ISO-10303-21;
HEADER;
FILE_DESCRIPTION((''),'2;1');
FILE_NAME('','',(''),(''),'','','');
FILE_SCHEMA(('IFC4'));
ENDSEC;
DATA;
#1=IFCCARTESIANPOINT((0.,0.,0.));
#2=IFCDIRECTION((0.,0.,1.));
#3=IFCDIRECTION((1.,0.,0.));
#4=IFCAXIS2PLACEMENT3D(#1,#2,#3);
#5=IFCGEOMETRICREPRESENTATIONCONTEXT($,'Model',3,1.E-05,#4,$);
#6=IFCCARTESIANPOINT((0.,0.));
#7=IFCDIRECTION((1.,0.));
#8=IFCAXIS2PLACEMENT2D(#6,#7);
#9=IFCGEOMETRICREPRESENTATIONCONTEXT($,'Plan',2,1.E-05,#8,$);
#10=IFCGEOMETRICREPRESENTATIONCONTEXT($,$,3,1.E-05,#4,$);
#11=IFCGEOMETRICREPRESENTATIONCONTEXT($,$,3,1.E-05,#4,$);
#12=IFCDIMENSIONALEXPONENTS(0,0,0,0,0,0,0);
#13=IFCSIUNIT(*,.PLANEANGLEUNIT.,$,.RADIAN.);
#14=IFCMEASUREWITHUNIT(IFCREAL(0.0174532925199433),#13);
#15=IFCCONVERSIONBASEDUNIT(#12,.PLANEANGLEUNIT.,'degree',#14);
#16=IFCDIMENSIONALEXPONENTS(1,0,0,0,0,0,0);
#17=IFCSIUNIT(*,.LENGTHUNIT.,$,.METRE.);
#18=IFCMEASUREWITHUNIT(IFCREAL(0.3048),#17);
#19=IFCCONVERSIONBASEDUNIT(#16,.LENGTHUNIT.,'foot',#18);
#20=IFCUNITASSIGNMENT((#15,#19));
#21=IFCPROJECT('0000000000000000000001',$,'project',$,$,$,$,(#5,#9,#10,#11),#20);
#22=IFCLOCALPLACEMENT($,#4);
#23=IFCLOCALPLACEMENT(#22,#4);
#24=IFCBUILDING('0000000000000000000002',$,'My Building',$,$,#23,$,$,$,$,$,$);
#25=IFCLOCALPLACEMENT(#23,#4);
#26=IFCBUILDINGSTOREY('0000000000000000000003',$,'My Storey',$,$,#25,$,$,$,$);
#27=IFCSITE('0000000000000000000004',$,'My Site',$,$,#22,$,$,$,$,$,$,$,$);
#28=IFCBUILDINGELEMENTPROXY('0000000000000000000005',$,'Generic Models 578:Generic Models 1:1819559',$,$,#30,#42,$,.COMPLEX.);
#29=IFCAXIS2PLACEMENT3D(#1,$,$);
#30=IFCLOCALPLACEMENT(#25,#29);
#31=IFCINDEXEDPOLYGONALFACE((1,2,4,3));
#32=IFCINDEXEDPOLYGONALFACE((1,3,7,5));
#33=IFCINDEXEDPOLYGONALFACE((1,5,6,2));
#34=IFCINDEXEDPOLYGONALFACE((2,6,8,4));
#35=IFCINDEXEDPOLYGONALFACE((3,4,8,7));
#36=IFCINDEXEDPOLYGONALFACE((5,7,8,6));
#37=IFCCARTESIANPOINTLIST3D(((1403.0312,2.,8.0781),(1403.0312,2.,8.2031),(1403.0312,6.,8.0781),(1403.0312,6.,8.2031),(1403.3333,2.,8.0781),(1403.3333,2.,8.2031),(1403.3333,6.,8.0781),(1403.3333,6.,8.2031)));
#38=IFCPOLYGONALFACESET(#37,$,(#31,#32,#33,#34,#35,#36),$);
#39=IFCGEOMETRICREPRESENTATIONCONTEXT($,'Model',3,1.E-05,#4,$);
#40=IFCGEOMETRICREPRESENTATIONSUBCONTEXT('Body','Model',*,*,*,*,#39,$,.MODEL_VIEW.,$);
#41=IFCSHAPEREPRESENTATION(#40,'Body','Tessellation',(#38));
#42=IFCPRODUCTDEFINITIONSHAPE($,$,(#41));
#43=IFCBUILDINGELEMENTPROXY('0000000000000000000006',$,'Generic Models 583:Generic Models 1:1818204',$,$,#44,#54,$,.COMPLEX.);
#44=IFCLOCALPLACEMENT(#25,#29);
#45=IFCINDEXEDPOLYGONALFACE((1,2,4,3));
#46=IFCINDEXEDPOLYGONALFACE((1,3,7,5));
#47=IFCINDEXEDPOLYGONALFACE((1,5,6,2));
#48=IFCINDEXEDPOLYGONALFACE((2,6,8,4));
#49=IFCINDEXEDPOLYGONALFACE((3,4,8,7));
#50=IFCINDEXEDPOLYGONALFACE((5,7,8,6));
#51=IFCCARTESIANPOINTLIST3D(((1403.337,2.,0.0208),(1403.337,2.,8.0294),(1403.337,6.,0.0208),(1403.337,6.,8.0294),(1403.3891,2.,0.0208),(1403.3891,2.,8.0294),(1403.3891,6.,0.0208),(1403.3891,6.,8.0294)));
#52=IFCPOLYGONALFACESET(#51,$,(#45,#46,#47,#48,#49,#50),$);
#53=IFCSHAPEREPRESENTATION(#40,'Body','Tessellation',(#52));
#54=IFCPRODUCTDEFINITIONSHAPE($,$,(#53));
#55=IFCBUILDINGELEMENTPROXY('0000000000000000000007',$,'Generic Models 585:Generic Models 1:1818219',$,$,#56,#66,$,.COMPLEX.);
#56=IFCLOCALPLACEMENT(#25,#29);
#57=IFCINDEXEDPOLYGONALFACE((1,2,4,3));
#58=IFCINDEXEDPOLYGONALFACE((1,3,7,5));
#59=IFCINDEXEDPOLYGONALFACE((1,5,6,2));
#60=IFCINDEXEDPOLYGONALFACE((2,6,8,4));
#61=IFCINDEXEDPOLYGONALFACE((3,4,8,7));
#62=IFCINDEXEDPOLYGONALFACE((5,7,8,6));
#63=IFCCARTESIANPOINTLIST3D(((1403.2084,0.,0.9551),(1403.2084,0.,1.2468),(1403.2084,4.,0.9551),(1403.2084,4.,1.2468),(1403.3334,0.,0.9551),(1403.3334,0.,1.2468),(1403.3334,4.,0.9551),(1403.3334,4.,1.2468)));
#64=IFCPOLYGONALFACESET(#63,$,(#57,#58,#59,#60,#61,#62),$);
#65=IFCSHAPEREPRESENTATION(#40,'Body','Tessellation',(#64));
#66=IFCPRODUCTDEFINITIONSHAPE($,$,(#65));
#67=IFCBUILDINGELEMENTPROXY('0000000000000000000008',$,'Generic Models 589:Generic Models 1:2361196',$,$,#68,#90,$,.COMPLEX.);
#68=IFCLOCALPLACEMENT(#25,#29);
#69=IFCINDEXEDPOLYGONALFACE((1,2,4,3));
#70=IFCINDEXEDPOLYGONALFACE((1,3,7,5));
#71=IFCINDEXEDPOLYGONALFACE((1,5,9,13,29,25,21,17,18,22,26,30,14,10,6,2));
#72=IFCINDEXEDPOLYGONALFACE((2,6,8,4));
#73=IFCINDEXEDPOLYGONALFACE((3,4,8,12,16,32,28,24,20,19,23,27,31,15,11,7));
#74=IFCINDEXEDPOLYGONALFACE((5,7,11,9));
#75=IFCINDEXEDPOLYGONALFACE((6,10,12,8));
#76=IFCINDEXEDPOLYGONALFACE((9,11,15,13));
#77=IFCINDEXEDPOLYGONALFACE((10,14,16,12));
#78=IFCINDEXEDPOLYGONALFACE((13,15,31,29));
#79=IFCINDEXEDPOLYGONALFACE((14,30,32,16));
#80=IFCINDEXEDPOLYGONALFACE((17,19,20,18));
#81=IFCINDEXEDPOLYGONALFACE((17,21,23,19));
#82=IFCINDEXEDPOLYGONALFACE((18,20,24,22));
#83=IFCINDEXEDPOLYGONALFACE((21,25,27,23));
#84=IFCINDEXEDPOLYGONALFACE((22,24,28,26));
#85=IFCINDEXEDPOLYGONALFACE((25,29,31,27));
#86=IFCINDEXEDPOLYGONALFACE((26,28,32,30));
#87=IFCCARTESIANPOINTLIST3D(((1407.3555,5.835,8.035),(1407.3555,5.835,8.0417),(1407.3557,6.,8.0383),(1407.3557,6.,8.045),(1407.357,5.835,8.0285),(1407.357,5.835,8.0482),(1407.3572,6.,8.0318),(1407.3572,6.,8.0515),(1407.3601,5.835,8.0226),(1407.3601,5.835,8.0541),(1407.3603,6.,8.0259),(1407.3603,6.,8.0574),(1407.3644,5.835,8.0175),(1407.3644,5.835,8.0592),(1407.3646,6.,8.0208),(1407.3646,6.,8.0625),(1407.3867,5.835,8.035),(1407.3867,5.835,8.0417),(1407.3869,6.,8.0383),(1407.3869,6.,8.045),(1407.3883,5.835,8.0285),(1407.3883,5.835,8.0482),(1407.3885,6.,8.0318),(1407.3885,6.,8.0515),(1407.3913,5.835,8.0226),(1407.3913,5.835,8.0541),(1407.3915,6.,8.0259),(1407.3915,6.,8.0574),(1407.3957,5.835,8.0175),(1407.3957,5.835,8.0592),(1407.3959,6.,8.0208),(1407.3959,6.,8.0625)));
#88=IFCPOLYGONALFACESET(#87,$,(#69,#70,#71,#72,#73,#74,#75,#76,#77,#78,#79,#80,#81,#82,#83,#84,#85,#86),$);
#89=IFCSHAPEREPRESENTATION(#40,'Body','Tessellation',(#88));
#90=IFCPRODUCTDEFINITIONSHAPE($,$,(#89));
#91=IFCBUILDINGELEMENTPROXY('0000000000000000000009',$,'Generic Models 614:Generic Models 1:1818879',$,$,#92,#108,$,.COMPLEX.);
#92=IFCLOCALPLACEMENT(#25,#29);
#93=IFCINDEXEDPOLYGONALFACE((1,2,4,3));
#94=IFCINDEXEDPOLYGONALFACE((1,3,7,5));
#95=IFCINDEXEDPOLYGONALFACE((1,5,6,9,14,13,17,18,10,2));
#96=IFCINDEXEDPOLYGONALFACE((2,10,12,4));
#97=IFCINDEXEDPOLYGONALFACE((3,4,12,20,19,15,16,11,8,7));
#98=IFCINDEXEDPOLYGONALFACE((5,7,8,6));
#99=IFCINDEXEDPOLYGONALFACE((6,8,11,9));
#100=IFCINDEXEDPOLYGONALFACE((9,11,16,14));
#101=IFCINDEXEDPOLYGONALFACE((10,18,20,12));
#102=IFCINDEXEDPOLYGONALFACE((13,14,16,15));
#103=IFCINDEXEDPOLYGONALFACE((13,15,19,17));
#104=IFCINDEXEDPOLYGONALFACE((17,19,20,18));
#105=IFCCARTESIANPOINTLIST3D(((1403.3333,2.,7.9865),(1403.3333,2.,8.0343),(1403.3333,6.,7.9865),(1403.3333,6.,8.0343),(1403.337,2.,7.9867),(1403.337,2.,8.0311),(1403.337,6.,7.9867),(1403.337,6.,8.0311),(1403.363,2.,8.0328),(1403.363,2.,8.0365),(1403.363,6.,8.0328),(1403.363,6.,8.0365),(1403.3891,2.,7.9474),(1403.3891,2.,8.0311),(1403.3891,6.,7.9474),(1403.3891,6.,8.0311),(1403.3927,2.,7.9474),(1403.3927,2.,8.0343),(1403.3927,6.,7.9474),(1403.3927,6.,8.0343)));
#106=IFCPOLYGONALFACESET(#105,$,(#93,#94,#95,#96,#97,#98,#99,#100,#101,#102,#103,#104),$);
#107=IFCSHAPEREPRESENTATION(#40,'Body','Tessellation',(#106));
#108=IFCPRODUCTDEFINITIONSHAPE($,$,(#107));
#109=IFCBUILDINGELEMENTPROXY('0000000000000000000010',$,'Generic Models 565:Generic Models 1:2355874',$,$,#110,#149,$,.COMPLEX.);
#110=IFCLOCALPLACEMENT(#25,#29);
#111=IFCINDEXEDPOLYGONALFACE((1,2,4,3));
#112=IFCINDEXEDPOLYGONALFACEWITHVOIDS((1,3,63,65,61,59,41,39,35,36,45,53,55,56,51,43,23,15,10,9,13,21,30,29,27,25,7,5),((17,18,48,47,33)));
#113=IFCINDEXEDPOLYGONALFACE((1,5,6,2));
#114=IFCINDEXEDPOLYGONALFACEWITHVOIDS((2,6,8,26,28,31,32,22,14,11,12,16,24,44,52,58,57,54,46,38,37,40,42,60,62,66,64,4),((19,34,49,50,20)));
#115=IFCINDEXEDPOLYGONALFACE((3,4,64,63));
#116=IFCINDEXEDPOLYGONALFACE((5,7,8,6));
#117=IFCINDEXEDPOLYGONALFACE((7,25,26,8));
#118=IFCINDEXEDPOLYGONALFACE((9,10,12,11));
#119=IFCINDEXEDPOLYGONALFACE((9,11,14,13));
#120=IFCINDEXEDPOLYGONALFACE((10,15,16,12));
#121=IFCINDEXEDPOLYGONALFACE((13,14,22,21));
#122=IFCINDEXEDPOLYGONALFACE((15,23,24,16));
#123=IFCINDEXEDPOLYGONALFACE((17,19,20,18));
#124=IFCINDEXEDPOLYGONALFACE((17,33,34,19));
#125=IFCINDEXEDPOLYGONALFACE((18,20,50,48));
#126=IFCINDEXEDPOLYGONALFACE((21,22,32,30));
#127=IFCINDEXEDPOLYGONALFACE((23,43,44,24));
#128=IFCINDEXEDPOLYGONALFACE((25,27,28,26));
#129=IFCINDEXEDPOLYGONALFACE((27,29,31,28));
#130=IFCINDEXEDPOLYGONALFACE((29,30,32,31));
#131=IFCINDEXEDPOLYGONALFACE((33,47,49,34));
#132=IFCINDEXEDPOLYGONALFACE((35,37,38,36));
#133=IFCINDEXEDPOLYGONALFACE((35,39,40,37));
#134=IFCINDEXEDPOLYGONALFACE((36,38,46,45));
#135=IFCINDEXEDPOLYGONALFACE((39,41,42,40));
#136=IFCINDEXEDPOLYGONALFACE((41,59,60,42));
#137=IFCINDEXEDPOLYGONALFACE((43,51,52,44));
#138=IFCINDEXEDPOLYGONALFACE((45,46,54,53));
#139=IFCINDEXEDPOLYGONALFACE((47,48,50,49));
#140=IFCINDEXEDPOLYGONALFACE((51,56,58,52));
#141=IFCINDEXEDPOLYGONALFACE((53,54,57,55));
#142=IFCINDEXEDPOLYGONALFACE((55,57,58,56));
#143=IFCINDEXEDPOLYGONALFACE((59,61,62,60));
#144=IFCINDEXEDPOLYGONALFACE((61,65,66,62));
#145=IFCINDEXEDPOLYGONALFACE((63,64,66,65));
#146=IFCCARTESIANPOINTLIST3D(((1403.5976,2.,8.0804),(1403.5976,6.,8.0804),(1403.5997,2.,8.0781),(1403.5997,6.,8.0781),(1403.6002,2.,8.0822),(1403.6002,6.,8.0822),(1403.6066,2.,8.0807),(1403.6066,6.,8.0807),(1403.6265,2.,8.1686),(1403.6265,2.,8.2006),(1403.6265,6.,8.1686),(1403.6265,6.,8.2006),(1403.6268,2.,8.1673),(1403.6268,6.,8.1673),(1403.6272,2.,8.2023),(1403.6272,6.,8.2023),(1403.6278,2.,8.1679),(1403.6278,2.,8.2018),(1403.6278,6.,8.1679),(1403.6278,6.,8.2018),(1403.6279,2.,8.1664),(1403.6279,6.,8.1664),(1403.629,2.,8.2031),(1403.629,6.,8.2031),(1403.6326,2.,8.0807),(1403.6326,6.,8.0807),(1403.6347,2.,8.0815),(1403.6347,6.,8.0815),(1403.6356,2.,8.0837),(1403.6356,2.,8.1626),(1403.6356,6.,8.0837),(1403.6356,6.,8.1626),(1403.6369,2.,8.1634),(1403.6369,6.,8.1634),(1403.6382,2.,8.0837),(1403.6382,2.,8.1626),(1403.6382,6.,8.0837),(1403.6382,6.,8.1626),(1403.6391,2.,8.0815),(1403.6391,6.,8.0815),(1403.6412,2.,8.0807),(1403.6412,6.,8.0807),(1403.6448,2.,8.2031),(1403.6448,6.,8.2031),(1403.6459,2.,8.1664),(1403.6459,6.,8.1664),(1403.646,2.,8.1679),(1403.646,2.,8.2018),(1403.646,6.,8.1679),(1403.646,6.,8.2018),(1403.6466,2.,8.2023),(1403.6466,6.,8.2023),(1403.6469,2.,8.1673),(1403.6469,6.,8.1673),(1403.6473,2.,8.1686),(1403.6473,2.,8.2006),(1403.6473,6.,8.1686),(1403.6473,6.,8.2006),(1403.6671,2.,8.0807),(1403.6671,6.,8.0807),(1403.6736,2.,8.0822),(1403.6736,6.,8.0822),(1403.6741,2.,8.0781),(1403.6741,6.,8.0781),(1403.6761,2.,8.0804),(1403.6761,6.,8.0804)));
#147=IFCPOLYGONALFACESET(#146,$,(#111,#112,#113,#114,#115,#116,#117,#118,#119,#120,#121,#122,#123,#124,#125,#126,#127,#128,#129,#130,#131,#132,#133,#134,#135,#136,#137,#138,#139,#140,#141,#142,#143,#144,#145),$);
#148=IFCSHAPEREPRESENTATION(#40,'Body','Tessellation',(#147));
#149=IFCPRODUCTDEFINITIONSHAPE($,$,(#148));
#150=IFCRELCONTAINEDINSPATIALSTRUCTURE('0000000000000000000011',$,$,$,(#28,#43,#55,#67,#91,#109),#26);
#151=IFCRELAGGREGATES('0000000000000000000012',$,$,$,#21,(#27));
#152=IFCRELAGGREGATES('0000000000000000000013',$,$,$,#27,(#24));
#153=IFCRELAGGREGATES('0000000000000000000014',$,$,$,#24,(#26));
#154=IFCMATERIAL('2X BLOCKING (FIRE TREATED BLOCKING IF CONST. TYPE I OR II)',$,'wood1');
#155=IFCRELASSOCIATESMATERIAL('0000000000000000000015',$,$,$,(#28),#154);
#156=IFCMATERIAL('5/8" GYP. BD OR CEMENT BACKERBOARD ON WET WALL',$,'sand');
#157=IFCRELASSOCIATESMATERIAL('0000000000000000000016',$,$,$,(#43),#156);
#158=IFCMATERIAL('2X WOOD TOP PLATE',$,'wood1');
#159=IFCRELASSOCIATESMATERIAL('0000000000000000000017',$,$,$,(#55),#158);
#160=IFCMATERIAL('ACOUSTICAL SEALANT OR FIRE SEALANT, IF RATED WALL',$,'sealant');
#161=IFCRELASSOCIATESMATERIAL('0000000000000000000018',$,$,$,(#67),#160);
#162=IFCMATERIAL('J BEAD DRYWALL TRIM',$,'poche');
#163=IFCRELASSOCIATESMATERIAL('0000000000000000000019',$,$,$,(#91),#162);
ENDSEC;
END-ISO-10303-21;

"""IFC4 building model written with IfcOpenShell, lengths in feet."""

from ifc_helpers import new_model, entity, si_unit, converted_unit, frame, origin_with_axes, origin_2d_with_axis, place, context, subcontext, project, spatial, polyline, line, indexed_curve, outline, extrude, material, element, save


model = new_model("IFC4")

# Units and contexts
model_context_1 = context("Model", 3, precision=1e-05, world=origin_with_axes())
plan_context = context("Plan", 2, precision=1e-05, world=origin_2d_with_axis())
model_context_2 = context("Model", 3, precision=1e-05, world=origin_with_axes())
context_of_model_1 = context(None, 3, precision=1e-05, world=origin_with_axes())
context_of_model_2 = context(None, 3, precision=1e-05, world=origin_with_axes())
body_context = subcontext(model_context_2, "Body", "Model", "MODEL_VIEW")
ifc_project = project(units=[converted_unit("PLANEANGLEUNIT", "degree", entity("IfcReal", 0.0174532925199433), si_unit("PLANEANGLEUNIT", "RADIAN"), dimensions=[0, 0, 0, 0, 0, 0, 0]), converted_unit("LENGTHUNIT", "foot", entity("IfcReal", 0.3048), si_unit("LENGTHUNIT", "METRE"), dimensions=[1, 0, 0, 0, 0, 0, 0])], contexts=[model_context_1, plan_context, context_of_model_1, context_of_model_2])

# Site, building, storey
site_placement = place(None, origin_with_axes())
site = spatial("IfcSite", under=ifc_project, at=site_placement, Name="My Site")
building_placement = place(site_placement, origin_with_axes())
building = spatial("IfcBuilding", under=site, at=building_placement, Name="My Building")
storey_placement = place(building_placement, origin_with_axes())
storey = spatial("IfcBuildingStorey", under=building, at=storey_placement, Name="My Storey")

# Building element proxies
ifc_material_1 = material(Name="ACOUSTICAL SEALANT OR FIRE SEALANT, IF RATED WALL", Category="sealant")
ifc_material_2 = material(Name="5/8\" GYP. BD OR CEMENT BACKERBOARD ON WET WALL", Category="sand")
ifc_material_3 = material(Name="2X WOOD TOP PLATE", Category="wood1")
ifc_material_4 = material(Name="2X BLOCKING (FIRE TREATED BLOCKING IF CONST. TYPE I OR II)", Category="wood1")
proxy_1_placement = place(storey_placement, frame((1403.0312, 6.0, 8.0781), z_axis=(0.0, -1.0, 0.0), x_axis=(0.0, 0.0, 1.0)))
element("IfcBuildingElementProxy", 1, at=proxy_1_placement, inside=storey, material=ifc_material_4, Name="Generic Models 578:Generic Models 1:1819559", PredefinedType="COMPLEX", context=body_context, shape_type="SweptSolid", body=[
    extrude(outline(polyline([(-0.0625, -0.151), (0.0625, -0.151), (0.0625, 0.151), (-0.0625, 0.151), (-0.0625, -0.151)])), frame((0.0625, -0.151, 0.0), z_axis=(0.0, 0.0, -1.0), x_axis=(-1.0, 0.0, 0.0)), (0.0, 0.0, -1.0), 4.0),
])
proxy_2_placement = place(storey_placement, frame((1403.337, 6.0, 0.0208), z_axis=(0.0, -1.0, 0.0), x_axis=(0.0, 0.0, 1.0)))
element("IfcBuildingElementProxy", 2, at=proxy_2_placement, inside=storey, material=ifc_material_2, Name="Generic Models 583:Generic Models 1:1818204", PredefinedType="COMPLEX", context=body_context, shape_type="SweptSolid", body=[
    extrude(outline(indexed_curve([(-4.0043, -0.026), (4.0043, -0.026), (4.0043, 0.026), (-4.0043, 0.026)], segments=[line(3, 2), line(2, 1), line(1, 4), line(4, 3)], self_intersect=False)), frame((4.0043, -0.026, 0.0), z_axis=(0.0, 0.0, -1.0), x_axis=(-1.0, 0.0, 0.0)), (0.0, 0.0, -1.0), 4.0),
])
proxy_3_placement = place(storey_placement, frame((1403.2084, 0.0, 0.9551), z_axis=(0.0, 0.0, 1.0), x_axis=(0.0, 1.0, 0.0)))
element("IfcBuildingElementProxy", 3, at=proxy_3_placement, inside=storey, material=ifc_material_3, Name="Generic Models 585:Generic Models 1:1818219", PredefinedType="COMPLEX", context=body_context, shape_type="SweptSolid", body=[
    extrude(outline(polyline([(-2.0, -0.0625), (2.0, -0.0625), (2.0, 0.0625), (-2.0, 0.0625), (-2.0, -0.0625)])), frame((2.0, -0.0625, 0.0), z_axis=(0.0, 0.0, -1.0), x_axis=(1.0, 0.0, 0.0)), (0.0, 0.0, -1.0), 0.2917),
])
proxy_4_placement = place(storey_placement, frame((1407.3557, 6.0, 8.0208), z_axis=(0.0, -1.0, 0.0), x_axis=(0.0, 0.0, 1.0)))
element("IfcBuildingElementProxy", 4, at=proxy_4_placement, inside=storey, material=ifc_material_1, Name="Generic Models 589:Generic Models 1:2361196", PredefinedType="COMPLEX", context=body_context, shape_type="SweptSolid", body=[
    extrude(outline(polyline([(0.0204, 0.0), (0.0206, 0.0067), (0.0192, 0.0132), (-0.0082, 0.0283), (-0.0068, 0.0217), (-0.007, 0.0151), (-0.0088, 0.0086), (-0.012, 0.0028), (-0.0165, -0.0021), (-0.022, -0.0059), (-0.0283, -0.0082), (-0.0009, -0.0233), (0.0054, -0.021), (0.0109, -0.0172), (0.0154, -0.0123), (0.0186, -0.0064), (0.0204, 0.0)])), frame((0.0208, -0.0194, 0.0), z_axis=(0.0, 0.0, -1.0), x_axis=(0.482454, 0.875921, 0.0)), (-0.008711, -0.018298, -0.999795), 0.165),
])
ifc_material_5 = material(Name="J BEAD DRYWALL TRIM", Category="poche")
proxy_5_placement = place(storey_placement, frame((1403.3333, 6.0, 7.9474), z_axis=(0.0, -1.0, 0.0), x_axis=(0.0, 0.0, 1.0)))
element("IfcBuildingElementProxy", 5, at=proxy_5_placement, inside=storey, material=ifc_material_5, Name="Generic Models 614:Generic Models 1:1818879", PredefinedType="COMPLEX", context=body_context, shape_type="SweptSolid", body=[
    extrude(outline(indexed_curve([(-0.0203, -0.0297), (0.0275, -0.0297), (0.0296, 0.0), (0.0275, 0.0297), (-0.0594, 0.0297), (-0.0594, 0.026), (0.0243, 0.026), (0.026, 0.0), (0.0243, -0.026), (-0.0201, -0.026)], segments=[line(3, 2), line(2, 1), line(1, 10), line(10, 9), line(9, 8), line(8, 7), line(7, 6), line(6, 5), line(5, 4), line(4, 3)], self_intersect=False)), frame((0.0594, -0.0297, 0.0), z_axis=(0.0, 0.0, -1.0), x_axis=(1.0, 0.0, 0.0)), (0.0, 0.0, -1.0), 4.0),
])
proxy_6_placement = place(storey_placement, frame((1403.5976, 6.0, 8.0781), z_axis=(0.0, -1.0, 0.0), x_axis=(0.0, 0.0, 1.0)))
element("IfcBuildingElementProxy", 6, at=proxy_6_placement, inside=storey, Name="Generic Models 565:Generic Models 1:2355874", PredefinedType="COMPLEX", context=body_context, shape_type="SweptSolid", body=[
    extrude(outline(indexed_curve([(0.0297, 0.0058), (0.0311, 0.006), (0.0627, 0.0015), (0.0643, 0.0005), (0.0648, -0.0014), (0.0625, -0.017), (0.0615, -0.0187), (0.0597, -0.0192), (0.0281, -0.0146), (0.0268, -0.014), (0.0261, -0.0129), (0.0234, -0.0047), (-0.0547, 0.0066), (-0.0569, 0.006), (-0.0581, 0.0041), (-0.0618, -0.0216), (-0.0612, -0.0282), (-0.0634, -0.0305), (-0.0654, -0.0281), (-0.0547, 0.0455), (-0.0522, 0.0472), (-0.0507, 0.0444), (-0.0532, 0.0382), (-0.0569, 0.0126), (-0.0563, 0.0103), (-0.0543, 0.0092), (0.0238, -0.0021), (0.0286, 0.005), (0.0301, 0.0048), (0.0637, 0.0), (0.0611, -0.018), (0.0275, -0.0132), (0.0244, -0.0035)], segments=[line(7, 6), line(6, 5), line(5, 4), line(4, 3), line(3, 2), line(2, 1), line(1, 28), line(28, 27), line(27, 26), line(26, 25), line(25, 24), line(24, 23), line(23, 22), line(22, 21), line(21, 20), line(20, 19), line(19, 18), line(18, 17), line(17, 16), line(16, 15), line(15, 14), line(14, 13), line(13, 12), line(12, 11), line(11, 10), line(10, 9), line(9, 8), line(8, 7)], self_intersect=False), holes=[indexed_curve([(0.0297, 0.0058), (0.0311, 0.006), (0.0627, 0.0015), (0.0643, 0.0005), (0.0648, -0.0014), (0.0625, -0.017), (0.0615, -0.0187), (0.0597, -0.0192), (0.0281, -0.0146), (0.0268, -0.014), (0.0261, -0.0129), (0.0234, -0.0047), (-0.0547, 0.0066), (-0.0569, 0.006), (-0.0581, 0.0041), (-0.0618, -0.0216), (-0.0612, -0.0282), (-0.0634, -0.0305), (-0.0654, -0.0281), (-0.0547, 0.0455), (-0.0522, 0.0472), (-0.0507, 0.0444), (-0.0532, 0.0382), (-0.0569, 0.0126), (-0.0563, 0.0103), (-0.0543, 0.0092), (0.0238, -0.0021), (0.0286, 0.005), (0.0301, 0.0048), (0.0637, 0.0), (0.0611, -0.018), (0.0275, -0.0132), (0.0244, -0.0035)], segments=[line(31, 32), line(32, 33), line(33, 29), line(29, 30), line(30, 31)], self_intersect=False)]), frame((0.0607, -0.0392, 0.0), z_axis=(0.0, 0.0, -1.0), x_axis=(0.989698, -0.14317, 0.0)), (0.0, 0.0, -1.0), 4.0),
])

save(model, "model.ifc")
